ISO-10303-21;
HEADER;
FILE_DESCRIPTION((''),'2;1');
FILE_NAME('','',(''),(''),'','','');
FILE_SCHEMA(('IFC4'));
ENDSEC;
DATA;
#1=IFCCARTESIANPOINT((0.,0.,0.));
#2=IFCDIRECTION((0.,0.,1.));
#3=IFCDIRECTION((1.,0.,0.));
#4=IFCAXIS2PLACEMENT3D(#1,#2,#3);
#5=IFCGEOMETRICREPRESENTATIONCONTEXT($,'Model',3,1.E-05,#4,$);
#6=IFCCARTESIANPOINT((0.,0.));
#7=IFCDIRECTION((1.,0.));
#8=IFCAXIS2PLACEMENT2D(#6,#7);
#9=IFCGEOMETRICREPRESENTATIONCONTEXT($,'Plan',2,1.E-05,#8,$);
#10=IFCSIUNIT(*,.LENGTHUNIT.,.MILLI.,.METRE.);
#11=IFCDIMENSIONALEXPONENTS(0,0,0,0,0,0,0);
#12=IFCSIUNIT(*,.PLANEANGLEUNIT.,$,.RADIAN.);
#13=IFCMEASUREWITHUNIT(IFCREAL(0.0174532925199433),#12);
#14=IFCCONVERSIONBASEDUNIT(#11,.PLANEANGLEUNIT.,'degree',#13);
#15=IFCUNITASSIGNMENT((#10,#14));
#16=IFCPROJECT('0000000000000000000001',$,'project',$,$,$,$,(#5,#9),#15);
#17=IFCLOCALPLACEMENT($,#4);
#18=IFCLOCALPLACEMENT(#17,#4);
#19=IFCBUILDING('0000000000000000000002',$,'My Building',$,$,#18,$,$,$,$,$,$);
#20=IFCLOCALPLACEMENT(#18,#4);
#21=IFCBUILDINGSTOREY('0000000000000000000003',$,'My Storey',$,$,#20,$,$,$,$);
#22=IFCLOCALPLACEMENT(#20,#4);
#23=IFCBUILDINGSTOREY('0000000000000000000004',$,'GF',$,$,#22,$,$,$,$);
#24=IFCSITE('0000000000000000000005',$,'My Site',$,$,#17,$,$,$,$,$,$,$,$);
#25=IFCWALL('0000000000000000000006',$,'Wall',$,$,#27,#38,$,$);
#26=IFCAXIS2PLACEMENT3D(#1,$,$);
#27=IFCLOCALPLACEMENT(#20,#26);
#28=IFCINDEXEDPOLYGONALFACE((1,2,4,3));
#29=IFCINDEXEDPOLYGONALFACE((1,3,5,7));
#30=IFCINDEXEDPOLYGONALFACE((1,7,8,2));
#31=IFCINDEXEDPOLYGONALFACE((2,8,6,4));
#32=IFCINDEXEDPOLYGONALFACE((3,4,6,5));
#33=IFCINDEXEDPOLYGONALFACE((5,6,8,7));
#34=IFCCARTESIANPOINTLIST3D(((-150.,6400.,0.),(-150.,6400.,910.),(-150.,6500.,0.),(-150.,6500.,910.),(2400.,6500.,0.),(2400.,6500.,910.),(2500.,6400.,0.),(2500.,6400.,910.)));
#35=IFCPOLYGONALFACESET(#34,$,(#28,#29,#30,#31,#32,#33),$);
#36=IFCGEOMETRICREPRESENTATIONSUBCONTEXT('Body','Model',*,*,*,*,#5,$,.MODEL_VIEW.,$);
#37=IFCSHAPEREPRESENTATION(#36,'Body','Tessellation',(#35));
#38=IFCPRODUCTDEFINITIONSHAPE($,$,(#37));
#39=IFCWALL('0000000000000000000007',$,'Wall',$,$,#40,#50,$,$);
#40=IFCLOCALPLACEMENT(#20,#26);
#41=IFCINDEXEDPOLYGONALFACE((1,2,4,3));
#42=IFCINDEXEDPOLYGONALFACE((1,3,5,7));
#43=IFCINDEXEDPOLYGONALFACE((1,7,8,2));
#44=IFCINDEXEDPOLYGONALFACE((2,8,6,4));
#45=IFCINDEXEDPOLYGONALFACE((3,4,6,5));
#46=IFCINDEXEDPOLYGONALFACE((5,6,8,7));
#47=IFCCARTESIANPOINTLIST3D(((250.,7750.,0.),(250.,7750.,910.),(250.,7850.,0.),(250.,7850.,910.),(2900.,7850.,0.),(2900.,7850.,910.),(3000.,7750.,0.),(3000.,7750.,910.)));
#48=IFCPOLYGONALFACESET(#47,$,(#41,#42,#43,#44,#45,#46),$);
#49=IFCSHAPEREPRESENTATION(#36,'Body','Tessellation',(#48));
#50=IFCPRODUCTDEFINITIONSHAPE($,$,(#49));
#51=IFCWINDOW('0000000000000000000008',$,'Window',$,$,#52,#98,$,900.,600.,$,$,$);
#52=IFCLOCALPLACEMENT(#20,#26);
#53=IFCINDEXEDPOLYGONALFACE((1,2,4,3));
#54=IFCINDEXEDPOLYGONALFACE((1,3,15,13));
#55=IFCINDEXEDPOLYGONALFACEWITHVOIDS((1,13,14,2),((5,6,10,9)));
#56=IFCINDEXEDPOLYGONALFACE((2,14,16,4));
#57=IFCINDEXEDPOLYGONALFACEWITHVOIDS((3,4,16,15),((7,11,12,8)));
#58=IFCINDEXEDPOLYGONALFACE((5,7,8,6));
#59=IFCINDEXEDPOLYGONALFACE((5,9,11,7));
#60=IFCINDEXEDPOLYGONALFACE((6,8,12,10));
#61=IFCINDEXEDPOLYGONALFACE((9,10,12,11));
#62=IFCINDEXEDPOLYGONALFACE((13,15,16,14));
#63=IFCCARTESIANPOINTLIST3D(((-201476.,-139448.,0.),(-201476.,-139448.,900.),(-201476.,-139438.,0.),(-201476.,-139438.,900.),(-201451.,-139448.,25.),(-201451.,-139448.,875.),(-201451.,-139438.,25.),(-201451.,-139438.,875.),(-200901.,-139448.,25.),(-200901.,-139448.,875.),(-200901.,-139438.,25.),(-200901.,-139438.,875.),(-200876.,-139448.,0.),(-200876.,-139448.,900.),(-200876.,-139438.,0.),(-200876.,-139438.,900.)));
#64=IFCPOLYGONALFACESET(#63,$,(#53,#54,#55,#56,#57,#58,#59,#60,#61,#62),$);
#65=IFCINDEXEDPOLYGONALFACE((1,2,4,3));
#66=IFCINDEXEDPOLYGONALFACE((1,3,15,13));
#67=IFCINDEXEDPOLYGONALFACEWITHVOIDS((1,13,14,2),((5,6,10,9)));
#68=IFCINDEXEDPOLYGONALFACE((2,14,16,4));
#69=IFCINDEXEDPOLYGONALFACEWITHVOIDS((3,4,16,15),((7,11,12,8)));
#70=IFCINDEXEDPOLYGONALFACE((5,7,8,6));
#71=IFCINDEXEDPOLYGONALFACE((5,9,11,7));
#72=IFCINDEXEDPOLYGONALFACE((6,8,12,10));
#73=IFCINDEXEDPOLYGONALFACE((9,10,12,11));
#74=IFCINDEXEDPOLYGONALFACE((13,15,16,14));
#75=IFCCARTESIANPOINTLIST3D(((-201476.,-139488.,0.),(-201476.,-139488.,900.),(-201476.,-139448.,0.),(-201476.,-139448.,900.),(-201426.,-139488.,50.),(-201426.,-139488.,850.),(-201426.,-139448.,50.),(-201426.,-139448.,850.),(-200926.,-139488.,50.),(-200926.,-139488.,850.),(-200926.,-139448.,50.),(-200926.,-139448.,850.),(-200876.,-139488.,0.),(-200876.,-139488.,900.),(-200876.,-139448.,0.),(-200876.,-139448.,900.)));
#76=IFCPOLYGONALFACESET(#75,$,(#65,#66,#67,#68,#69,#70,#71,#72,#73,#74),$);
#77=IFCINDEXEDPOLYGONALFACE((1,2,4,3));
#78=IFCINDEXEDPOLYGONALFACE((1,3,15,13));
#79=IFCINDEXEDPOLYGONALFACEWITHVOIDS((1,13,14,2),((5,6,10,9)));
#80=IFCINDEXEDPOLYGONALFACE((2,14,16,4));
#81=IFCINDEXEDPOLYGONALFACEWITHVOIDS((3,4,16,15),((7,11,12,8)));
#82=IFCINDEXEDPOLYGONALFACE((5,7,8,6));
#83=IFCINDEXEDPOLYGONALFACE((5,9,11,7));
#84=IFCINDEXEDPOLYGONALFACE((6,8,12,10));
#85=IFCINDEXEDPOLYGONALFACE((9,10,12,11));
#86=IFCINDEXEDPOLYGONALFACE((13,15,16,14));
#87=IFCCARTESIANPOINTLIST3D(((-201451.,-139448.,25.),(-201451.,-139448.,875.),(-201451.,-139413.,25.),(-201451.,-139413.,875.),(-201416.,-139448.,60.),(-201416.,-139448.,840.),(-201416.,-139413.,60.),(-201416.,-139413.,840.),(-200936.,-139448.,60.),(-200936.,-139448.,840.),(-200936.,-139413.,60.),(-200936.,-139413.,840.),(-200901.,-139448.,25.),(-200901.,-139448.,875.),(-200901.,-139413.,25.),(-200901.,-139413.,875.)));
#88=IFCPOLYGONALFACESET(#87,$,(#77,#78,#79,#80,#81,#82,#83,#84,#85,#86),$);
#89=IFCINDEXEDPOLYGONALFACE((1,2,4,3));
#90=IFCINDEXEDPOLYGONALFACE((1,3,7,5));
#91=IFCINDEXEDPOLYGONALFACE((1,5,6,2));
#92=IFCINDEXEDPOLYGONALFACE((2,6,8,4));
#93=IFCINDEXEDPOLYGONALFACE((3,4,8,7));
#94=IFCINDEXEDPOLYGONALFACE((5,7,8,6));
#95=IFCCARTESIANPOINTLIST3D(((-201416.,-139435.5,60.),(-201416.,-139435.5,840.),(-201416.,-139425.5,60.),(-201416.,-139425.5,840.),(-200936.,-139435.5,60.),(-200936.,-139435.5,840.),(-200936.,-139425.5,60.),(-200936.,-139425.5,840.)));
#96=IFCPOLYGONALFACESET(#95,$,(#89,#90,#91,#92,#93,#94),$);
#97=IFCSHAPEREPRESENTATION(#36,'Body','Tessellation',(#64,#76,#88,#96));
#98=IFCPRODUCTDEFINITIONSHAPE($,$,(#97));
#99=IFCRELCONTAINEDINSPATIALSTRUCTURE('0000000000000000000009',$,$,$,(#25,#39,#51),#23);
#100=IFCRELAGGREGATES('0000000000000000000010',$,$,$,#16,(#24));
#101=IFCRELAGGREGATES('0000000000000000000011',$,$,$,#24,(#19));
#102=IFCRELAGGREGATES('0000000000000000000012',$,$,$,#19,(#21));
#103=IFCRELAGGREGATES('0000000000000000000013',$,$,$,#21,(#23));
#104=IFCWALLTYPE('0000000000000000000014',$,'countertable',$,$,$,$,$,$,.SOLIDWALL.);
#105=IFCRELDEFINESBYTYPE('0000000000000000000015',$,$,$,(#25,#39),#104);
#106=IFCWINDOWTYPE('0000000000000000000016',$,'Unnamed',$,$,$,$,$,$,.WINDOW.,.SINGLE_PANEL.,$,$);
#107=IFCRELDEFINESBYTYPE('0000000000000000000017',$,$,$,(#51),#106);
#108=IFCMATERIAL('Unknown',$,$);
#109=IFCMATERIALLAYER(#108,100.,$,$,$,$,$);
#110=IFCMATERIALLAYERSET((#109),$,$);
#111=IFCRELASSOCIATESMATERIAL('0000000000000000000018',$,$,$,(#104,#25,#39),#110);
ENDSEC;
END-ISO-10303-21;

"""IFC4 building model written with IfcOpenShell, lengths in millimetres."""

from ifc_helpers import new_model, entity, si_unit, converted_unit, frame, origin_with_axes, origin_2d_with_axis, place, context, subcontext, project, spatial, line, indexed_curve, outline, extrude, shape, source, transform, mapped, material, layer, layer_set, layer_usage, type_object, type_shapes, element, save


model = new_model("IFC4")

# Units and contexts
model_context = context("Model", 3, precision=1e-05, world=origin_with_axes())
plan_context = context("Plan", 2, precision=1e-05, world=origin_2d_with_axis())
body_context_1 = subcontext(model_context, "Body", "Model", "MODEL_VIEW")
body_context_2 = subcontext(plan_context, "Body", "Plan", "PLAN_VIEW")
ifc_project = project(units=[si_unit("LENGTHUNIT", "METRE", prefix="MILLI"), converted_unit("PLANEANGLEUNIT", "degree", entity("IfcReal", 0.0174532925199433), si_unit("PLANEANGLEUNIT", "RADIAN"), dimensions=[0, 0, 0, 0, 0, 0, 0])], contexts=[model_context, plan_context])

# Site, building, storeys
site_placement = place(None, origin_with_axes())
site = spatial("IfcSite", under=ifc_project, at=site_placement, Name="My Site")
building_placement = place(site_placement, origin_with_axes())
building = spatial("IfcBuilding", under=site, at=building_placement, Name="My Building")
storey_1_placement = place(building_placement, origin_with_axes())
storey_1 = spatial("IfcBuildingStorey", under=building, at=storey_1_placement, Name="My Storey")
storey_2_placement = place(storey_1_placement, origin_with_axes())
storey_2 = spatial("IfcBuildingStorey", under=storey_1, at=storey_2_placement, Name="GF")

# Shared definitions
ifc_material = material(Name="Unknown")

# Walls
ifc_layer_1 = layer(ifc_material, 100.0)
ifc_layer_set_1 = layer_set([ifc_layer_1])
wall_type_1 = type_object("IfcWallType", Name="countertable", PredefinedType="SOLIDWALL", material=ifc_layer_set_1)
ifc_layer_usage_1 = layer_usage(ifc_layer_set_1, "AXIS2", "POSITIVE", 0.0)
wall_1_placement = place(storey_2_placement, frame((-150.0, 6400.0, 0.0), z_axis=(0.0, 0.0, 1.0), x_axis=(1.0, 0.0, 0.0)))
element("IfcWall", 1, at=wall_1_placement, inside=storey_2, type_object=wall_type_1, material=ifc_layer_usage_1, Name="Wall", context=body_context_1, shape_type="SweptSolid", body=[
    extrude(outline(indexed_curve([(0.0, 0.0), (0.0, 100.0), (2550.0, 100.0), (2650.0, 0.0)], segments=[line(1, 2, 3, 4, 1)])), origin_with_axes(), (0.0, 0.0, 1.0), 910.0),
])
ifc_layer_usage_2 = layer_usage(ifc_layer_set_1, "AXIS2", "POSITIVE", 0.0)
wall_2_placement = place(storey_2_placement, frame((250.0, 7750.0, 0.0), z_axis=(0.0, 0.0, 1.0), x_axis=(1.0, 0.0, 0.0)))
element("IfcWall", 2, at=wall_2_placement, inside=storey_2, type_object=wall_type_1, material=ifc_layer_usage_2, Name="Wall", context=body_context_1, shape_type="SweptSolid", body=[
    extrude(outline(indexed_curve([(0.0, 0.0), (0.0, 100.0), (2650.0, 100.0), (2750.0, 0.0)], segments=[line(1, 2, 3, 4, 1)])), origin_with_axes(), (0.0, 0.0, 1.0), 910.0),
])

# Window
window_type_1 = type_object("IfcWindowType", Name="Unnamed", PartitioningType="SINGLE_PANEL", PredefinedType="WINDOW")
shared_shape_1 = source(origin_with_axes(), body_context_1, "Body", "SweptSolid", [
    extrude(outline(indexed_curve([(0.0, 0.0), (600.0, 0.0), (600.0, 900.0), (0.0, 900.0)], segments=[line(1, 2, 3, 4, 1)]), holes=[indexed_curve([(25.0, 25.0), (575.0, 25.0), (575.0, 875.0), (25.0, 875.0)], segments=[line(1, 2, 3, 4, 1)])]), frame((0.0, 90.0, 0.0), z_axis=(0.0, -1.0, 0.0), x_axis=(1.0, 0.0, 0.0)), (0.0, 0.0, -1.0), 10.0),
    extrude(outline(indexed_curve([(0.0, 0.0), (600.0, 0.0), (600.0, 900.0), (0.0, 900.0)], segments=[line(1, 2, 3, 4, 1)]), holes=[indexed_curve([(50.0, 50.0), (550.0, 50.0), (550.0, 850.0), (50.0, 850.0)], segments=[line(1, 2, 3, 4, 1)])]), frame((0.0, 50.0, 0.0), z_axis=(0.0, -1.0, 0.0), x_axis=(1.0, 0.0, 0.0)), (0.0, 0.0, -1.0), 40.0),
    extrude(outline(indexed_curve([(0.0, 0.0), (550.0, 0.0), (550.0, 850.0), (0.0, 850.0)], segments=[line(1, 2, 3, 4, 1)]), holes=[indexed_curve([(35.0, 35.0), (515.0, 35.0), (515.0, 815.0), (35.0, 815.0)], segments=[line(1, 2, 3, 4, 1)])]), frame((25.0, 90.0, 25.0), z_axis=(0.0, -1.0, 0.0), x_axis=(1.0, 0.0, 0.0)), (0.0, 0.0, -1.0), 35.0),
    extrude(outline(indexed_curve([(35.0, 35.0), (515.0, 35.0), (515.0, 815.0), (35.0, 815.0)], segments=[line(1, 2, 3, 4, 1)])), frame((25.0, 102.5, 25.0), z_axis=(0.0, -1.0, 0.0), x_axis=(1.0, 0.0, 0.0)), (0.0, 0.0, -1.0), 10.0),
])
shared_shape_2 = source(origin_with_axes(), body_context_2, "Body", "Curve2D", [
    entity("IfcIndexedPolyCurve", entity("IfcCartesianPointList2D", [[50.0, 50.0], [550.0, 50.0]])),
    entity("IfcIndexedPolyCurve", entity("IfcCartesianPointList2D", [[0.0, 100.0], [25.0, 100.0], [25.0, 90.0], [50.0, 90.0], [50.0, 50.0], [0.0, 50.0]]), [entity("IfcLineIndex", [1, 2, 3, 4, 5, 6, 1])]),
    entity("IfcIndexedPolyCurve", entity("IfcCartesianPointList2D", [[600.0, 100.0], [575.0, 100.0], [575.0, 90.0], [550.0, 90.0], [550.0, 50.0], [600.0, 50.0]]), [entity("IfcLineIndex", [1, 2, 3, 4, 5, 6, 1])]),
    entity("IfcIndexedPolyCurve", entity("IfcCartesianPointList2D", [[25.0, 90.0], [60.0, 90.0], [60.0, 125.0], [25.0, 125.0]]), [entity("IfcLineIndex", [1, 2, 3, 4, 1])]),
    entity("IfcIndexedPolyCurve", entity("IfcCartesianPointList2D", [[575.0, 90.0], [540.0, 90.0], [540.0, 125.0], [575.0, 125.0]]), [entity("IfcLineIndex", [1, 2, 3, 4, 1])]),
    entity("IfcIndexedPolyCurve", entity("IfcCartesianPointList2D", [[60.0, 90.0], [540.0, 90.0]])),
    entity("IfcIndexedPolyCurve", entity("IfcCartesianPointList2D", [[60.0, 125.0], [540.0, 125.0]])),
    entity("IfcIndexedPolyCurve", entity("IfcCartesianPointList2D", [[60.0, 107.5], [540.0, 107.5]])),
])
type_shapes(window_type_1, [shared_shape_1, shared_shape_2])
window_1_placement = place(storey_2_placement, frame((-201476.0, -139538.0, 0.0), z_axis=(0.0, 0.0, 1.0), x_axis=(1.0, 0.0, 0.0)))
element("IfcWindow", 3, at=window_1_placement, inside=storey_2, type_object=window_type_1, Name="Window", OverallHeight=900.0, OverallWidth=600.0, shapes=[
    shape(body_context_1, "Body", "MappedRepresentation", [mapped(shared_shape_1, transform((0.0, 0.0, 0.0), x_axis=(1.0, 0.0, 0.0), y_axis=(0.0, 1.0, 0.0), z_axis=(0.0, 0.0, 1.0), scale=1.0))]),
    shape(body_context_2, "Body", "MappedRepresentation", [mapped(shared_shape_2, transform((0.0, 0.0, 0.0), x_axis=(1.0, 0.0, 0.0), y_axis=(0.0, 1.0, 0.0), z_axis=(0.0, 0.0, 1.0), scale=1.0))]),
])

save(model, "model.ifc")
